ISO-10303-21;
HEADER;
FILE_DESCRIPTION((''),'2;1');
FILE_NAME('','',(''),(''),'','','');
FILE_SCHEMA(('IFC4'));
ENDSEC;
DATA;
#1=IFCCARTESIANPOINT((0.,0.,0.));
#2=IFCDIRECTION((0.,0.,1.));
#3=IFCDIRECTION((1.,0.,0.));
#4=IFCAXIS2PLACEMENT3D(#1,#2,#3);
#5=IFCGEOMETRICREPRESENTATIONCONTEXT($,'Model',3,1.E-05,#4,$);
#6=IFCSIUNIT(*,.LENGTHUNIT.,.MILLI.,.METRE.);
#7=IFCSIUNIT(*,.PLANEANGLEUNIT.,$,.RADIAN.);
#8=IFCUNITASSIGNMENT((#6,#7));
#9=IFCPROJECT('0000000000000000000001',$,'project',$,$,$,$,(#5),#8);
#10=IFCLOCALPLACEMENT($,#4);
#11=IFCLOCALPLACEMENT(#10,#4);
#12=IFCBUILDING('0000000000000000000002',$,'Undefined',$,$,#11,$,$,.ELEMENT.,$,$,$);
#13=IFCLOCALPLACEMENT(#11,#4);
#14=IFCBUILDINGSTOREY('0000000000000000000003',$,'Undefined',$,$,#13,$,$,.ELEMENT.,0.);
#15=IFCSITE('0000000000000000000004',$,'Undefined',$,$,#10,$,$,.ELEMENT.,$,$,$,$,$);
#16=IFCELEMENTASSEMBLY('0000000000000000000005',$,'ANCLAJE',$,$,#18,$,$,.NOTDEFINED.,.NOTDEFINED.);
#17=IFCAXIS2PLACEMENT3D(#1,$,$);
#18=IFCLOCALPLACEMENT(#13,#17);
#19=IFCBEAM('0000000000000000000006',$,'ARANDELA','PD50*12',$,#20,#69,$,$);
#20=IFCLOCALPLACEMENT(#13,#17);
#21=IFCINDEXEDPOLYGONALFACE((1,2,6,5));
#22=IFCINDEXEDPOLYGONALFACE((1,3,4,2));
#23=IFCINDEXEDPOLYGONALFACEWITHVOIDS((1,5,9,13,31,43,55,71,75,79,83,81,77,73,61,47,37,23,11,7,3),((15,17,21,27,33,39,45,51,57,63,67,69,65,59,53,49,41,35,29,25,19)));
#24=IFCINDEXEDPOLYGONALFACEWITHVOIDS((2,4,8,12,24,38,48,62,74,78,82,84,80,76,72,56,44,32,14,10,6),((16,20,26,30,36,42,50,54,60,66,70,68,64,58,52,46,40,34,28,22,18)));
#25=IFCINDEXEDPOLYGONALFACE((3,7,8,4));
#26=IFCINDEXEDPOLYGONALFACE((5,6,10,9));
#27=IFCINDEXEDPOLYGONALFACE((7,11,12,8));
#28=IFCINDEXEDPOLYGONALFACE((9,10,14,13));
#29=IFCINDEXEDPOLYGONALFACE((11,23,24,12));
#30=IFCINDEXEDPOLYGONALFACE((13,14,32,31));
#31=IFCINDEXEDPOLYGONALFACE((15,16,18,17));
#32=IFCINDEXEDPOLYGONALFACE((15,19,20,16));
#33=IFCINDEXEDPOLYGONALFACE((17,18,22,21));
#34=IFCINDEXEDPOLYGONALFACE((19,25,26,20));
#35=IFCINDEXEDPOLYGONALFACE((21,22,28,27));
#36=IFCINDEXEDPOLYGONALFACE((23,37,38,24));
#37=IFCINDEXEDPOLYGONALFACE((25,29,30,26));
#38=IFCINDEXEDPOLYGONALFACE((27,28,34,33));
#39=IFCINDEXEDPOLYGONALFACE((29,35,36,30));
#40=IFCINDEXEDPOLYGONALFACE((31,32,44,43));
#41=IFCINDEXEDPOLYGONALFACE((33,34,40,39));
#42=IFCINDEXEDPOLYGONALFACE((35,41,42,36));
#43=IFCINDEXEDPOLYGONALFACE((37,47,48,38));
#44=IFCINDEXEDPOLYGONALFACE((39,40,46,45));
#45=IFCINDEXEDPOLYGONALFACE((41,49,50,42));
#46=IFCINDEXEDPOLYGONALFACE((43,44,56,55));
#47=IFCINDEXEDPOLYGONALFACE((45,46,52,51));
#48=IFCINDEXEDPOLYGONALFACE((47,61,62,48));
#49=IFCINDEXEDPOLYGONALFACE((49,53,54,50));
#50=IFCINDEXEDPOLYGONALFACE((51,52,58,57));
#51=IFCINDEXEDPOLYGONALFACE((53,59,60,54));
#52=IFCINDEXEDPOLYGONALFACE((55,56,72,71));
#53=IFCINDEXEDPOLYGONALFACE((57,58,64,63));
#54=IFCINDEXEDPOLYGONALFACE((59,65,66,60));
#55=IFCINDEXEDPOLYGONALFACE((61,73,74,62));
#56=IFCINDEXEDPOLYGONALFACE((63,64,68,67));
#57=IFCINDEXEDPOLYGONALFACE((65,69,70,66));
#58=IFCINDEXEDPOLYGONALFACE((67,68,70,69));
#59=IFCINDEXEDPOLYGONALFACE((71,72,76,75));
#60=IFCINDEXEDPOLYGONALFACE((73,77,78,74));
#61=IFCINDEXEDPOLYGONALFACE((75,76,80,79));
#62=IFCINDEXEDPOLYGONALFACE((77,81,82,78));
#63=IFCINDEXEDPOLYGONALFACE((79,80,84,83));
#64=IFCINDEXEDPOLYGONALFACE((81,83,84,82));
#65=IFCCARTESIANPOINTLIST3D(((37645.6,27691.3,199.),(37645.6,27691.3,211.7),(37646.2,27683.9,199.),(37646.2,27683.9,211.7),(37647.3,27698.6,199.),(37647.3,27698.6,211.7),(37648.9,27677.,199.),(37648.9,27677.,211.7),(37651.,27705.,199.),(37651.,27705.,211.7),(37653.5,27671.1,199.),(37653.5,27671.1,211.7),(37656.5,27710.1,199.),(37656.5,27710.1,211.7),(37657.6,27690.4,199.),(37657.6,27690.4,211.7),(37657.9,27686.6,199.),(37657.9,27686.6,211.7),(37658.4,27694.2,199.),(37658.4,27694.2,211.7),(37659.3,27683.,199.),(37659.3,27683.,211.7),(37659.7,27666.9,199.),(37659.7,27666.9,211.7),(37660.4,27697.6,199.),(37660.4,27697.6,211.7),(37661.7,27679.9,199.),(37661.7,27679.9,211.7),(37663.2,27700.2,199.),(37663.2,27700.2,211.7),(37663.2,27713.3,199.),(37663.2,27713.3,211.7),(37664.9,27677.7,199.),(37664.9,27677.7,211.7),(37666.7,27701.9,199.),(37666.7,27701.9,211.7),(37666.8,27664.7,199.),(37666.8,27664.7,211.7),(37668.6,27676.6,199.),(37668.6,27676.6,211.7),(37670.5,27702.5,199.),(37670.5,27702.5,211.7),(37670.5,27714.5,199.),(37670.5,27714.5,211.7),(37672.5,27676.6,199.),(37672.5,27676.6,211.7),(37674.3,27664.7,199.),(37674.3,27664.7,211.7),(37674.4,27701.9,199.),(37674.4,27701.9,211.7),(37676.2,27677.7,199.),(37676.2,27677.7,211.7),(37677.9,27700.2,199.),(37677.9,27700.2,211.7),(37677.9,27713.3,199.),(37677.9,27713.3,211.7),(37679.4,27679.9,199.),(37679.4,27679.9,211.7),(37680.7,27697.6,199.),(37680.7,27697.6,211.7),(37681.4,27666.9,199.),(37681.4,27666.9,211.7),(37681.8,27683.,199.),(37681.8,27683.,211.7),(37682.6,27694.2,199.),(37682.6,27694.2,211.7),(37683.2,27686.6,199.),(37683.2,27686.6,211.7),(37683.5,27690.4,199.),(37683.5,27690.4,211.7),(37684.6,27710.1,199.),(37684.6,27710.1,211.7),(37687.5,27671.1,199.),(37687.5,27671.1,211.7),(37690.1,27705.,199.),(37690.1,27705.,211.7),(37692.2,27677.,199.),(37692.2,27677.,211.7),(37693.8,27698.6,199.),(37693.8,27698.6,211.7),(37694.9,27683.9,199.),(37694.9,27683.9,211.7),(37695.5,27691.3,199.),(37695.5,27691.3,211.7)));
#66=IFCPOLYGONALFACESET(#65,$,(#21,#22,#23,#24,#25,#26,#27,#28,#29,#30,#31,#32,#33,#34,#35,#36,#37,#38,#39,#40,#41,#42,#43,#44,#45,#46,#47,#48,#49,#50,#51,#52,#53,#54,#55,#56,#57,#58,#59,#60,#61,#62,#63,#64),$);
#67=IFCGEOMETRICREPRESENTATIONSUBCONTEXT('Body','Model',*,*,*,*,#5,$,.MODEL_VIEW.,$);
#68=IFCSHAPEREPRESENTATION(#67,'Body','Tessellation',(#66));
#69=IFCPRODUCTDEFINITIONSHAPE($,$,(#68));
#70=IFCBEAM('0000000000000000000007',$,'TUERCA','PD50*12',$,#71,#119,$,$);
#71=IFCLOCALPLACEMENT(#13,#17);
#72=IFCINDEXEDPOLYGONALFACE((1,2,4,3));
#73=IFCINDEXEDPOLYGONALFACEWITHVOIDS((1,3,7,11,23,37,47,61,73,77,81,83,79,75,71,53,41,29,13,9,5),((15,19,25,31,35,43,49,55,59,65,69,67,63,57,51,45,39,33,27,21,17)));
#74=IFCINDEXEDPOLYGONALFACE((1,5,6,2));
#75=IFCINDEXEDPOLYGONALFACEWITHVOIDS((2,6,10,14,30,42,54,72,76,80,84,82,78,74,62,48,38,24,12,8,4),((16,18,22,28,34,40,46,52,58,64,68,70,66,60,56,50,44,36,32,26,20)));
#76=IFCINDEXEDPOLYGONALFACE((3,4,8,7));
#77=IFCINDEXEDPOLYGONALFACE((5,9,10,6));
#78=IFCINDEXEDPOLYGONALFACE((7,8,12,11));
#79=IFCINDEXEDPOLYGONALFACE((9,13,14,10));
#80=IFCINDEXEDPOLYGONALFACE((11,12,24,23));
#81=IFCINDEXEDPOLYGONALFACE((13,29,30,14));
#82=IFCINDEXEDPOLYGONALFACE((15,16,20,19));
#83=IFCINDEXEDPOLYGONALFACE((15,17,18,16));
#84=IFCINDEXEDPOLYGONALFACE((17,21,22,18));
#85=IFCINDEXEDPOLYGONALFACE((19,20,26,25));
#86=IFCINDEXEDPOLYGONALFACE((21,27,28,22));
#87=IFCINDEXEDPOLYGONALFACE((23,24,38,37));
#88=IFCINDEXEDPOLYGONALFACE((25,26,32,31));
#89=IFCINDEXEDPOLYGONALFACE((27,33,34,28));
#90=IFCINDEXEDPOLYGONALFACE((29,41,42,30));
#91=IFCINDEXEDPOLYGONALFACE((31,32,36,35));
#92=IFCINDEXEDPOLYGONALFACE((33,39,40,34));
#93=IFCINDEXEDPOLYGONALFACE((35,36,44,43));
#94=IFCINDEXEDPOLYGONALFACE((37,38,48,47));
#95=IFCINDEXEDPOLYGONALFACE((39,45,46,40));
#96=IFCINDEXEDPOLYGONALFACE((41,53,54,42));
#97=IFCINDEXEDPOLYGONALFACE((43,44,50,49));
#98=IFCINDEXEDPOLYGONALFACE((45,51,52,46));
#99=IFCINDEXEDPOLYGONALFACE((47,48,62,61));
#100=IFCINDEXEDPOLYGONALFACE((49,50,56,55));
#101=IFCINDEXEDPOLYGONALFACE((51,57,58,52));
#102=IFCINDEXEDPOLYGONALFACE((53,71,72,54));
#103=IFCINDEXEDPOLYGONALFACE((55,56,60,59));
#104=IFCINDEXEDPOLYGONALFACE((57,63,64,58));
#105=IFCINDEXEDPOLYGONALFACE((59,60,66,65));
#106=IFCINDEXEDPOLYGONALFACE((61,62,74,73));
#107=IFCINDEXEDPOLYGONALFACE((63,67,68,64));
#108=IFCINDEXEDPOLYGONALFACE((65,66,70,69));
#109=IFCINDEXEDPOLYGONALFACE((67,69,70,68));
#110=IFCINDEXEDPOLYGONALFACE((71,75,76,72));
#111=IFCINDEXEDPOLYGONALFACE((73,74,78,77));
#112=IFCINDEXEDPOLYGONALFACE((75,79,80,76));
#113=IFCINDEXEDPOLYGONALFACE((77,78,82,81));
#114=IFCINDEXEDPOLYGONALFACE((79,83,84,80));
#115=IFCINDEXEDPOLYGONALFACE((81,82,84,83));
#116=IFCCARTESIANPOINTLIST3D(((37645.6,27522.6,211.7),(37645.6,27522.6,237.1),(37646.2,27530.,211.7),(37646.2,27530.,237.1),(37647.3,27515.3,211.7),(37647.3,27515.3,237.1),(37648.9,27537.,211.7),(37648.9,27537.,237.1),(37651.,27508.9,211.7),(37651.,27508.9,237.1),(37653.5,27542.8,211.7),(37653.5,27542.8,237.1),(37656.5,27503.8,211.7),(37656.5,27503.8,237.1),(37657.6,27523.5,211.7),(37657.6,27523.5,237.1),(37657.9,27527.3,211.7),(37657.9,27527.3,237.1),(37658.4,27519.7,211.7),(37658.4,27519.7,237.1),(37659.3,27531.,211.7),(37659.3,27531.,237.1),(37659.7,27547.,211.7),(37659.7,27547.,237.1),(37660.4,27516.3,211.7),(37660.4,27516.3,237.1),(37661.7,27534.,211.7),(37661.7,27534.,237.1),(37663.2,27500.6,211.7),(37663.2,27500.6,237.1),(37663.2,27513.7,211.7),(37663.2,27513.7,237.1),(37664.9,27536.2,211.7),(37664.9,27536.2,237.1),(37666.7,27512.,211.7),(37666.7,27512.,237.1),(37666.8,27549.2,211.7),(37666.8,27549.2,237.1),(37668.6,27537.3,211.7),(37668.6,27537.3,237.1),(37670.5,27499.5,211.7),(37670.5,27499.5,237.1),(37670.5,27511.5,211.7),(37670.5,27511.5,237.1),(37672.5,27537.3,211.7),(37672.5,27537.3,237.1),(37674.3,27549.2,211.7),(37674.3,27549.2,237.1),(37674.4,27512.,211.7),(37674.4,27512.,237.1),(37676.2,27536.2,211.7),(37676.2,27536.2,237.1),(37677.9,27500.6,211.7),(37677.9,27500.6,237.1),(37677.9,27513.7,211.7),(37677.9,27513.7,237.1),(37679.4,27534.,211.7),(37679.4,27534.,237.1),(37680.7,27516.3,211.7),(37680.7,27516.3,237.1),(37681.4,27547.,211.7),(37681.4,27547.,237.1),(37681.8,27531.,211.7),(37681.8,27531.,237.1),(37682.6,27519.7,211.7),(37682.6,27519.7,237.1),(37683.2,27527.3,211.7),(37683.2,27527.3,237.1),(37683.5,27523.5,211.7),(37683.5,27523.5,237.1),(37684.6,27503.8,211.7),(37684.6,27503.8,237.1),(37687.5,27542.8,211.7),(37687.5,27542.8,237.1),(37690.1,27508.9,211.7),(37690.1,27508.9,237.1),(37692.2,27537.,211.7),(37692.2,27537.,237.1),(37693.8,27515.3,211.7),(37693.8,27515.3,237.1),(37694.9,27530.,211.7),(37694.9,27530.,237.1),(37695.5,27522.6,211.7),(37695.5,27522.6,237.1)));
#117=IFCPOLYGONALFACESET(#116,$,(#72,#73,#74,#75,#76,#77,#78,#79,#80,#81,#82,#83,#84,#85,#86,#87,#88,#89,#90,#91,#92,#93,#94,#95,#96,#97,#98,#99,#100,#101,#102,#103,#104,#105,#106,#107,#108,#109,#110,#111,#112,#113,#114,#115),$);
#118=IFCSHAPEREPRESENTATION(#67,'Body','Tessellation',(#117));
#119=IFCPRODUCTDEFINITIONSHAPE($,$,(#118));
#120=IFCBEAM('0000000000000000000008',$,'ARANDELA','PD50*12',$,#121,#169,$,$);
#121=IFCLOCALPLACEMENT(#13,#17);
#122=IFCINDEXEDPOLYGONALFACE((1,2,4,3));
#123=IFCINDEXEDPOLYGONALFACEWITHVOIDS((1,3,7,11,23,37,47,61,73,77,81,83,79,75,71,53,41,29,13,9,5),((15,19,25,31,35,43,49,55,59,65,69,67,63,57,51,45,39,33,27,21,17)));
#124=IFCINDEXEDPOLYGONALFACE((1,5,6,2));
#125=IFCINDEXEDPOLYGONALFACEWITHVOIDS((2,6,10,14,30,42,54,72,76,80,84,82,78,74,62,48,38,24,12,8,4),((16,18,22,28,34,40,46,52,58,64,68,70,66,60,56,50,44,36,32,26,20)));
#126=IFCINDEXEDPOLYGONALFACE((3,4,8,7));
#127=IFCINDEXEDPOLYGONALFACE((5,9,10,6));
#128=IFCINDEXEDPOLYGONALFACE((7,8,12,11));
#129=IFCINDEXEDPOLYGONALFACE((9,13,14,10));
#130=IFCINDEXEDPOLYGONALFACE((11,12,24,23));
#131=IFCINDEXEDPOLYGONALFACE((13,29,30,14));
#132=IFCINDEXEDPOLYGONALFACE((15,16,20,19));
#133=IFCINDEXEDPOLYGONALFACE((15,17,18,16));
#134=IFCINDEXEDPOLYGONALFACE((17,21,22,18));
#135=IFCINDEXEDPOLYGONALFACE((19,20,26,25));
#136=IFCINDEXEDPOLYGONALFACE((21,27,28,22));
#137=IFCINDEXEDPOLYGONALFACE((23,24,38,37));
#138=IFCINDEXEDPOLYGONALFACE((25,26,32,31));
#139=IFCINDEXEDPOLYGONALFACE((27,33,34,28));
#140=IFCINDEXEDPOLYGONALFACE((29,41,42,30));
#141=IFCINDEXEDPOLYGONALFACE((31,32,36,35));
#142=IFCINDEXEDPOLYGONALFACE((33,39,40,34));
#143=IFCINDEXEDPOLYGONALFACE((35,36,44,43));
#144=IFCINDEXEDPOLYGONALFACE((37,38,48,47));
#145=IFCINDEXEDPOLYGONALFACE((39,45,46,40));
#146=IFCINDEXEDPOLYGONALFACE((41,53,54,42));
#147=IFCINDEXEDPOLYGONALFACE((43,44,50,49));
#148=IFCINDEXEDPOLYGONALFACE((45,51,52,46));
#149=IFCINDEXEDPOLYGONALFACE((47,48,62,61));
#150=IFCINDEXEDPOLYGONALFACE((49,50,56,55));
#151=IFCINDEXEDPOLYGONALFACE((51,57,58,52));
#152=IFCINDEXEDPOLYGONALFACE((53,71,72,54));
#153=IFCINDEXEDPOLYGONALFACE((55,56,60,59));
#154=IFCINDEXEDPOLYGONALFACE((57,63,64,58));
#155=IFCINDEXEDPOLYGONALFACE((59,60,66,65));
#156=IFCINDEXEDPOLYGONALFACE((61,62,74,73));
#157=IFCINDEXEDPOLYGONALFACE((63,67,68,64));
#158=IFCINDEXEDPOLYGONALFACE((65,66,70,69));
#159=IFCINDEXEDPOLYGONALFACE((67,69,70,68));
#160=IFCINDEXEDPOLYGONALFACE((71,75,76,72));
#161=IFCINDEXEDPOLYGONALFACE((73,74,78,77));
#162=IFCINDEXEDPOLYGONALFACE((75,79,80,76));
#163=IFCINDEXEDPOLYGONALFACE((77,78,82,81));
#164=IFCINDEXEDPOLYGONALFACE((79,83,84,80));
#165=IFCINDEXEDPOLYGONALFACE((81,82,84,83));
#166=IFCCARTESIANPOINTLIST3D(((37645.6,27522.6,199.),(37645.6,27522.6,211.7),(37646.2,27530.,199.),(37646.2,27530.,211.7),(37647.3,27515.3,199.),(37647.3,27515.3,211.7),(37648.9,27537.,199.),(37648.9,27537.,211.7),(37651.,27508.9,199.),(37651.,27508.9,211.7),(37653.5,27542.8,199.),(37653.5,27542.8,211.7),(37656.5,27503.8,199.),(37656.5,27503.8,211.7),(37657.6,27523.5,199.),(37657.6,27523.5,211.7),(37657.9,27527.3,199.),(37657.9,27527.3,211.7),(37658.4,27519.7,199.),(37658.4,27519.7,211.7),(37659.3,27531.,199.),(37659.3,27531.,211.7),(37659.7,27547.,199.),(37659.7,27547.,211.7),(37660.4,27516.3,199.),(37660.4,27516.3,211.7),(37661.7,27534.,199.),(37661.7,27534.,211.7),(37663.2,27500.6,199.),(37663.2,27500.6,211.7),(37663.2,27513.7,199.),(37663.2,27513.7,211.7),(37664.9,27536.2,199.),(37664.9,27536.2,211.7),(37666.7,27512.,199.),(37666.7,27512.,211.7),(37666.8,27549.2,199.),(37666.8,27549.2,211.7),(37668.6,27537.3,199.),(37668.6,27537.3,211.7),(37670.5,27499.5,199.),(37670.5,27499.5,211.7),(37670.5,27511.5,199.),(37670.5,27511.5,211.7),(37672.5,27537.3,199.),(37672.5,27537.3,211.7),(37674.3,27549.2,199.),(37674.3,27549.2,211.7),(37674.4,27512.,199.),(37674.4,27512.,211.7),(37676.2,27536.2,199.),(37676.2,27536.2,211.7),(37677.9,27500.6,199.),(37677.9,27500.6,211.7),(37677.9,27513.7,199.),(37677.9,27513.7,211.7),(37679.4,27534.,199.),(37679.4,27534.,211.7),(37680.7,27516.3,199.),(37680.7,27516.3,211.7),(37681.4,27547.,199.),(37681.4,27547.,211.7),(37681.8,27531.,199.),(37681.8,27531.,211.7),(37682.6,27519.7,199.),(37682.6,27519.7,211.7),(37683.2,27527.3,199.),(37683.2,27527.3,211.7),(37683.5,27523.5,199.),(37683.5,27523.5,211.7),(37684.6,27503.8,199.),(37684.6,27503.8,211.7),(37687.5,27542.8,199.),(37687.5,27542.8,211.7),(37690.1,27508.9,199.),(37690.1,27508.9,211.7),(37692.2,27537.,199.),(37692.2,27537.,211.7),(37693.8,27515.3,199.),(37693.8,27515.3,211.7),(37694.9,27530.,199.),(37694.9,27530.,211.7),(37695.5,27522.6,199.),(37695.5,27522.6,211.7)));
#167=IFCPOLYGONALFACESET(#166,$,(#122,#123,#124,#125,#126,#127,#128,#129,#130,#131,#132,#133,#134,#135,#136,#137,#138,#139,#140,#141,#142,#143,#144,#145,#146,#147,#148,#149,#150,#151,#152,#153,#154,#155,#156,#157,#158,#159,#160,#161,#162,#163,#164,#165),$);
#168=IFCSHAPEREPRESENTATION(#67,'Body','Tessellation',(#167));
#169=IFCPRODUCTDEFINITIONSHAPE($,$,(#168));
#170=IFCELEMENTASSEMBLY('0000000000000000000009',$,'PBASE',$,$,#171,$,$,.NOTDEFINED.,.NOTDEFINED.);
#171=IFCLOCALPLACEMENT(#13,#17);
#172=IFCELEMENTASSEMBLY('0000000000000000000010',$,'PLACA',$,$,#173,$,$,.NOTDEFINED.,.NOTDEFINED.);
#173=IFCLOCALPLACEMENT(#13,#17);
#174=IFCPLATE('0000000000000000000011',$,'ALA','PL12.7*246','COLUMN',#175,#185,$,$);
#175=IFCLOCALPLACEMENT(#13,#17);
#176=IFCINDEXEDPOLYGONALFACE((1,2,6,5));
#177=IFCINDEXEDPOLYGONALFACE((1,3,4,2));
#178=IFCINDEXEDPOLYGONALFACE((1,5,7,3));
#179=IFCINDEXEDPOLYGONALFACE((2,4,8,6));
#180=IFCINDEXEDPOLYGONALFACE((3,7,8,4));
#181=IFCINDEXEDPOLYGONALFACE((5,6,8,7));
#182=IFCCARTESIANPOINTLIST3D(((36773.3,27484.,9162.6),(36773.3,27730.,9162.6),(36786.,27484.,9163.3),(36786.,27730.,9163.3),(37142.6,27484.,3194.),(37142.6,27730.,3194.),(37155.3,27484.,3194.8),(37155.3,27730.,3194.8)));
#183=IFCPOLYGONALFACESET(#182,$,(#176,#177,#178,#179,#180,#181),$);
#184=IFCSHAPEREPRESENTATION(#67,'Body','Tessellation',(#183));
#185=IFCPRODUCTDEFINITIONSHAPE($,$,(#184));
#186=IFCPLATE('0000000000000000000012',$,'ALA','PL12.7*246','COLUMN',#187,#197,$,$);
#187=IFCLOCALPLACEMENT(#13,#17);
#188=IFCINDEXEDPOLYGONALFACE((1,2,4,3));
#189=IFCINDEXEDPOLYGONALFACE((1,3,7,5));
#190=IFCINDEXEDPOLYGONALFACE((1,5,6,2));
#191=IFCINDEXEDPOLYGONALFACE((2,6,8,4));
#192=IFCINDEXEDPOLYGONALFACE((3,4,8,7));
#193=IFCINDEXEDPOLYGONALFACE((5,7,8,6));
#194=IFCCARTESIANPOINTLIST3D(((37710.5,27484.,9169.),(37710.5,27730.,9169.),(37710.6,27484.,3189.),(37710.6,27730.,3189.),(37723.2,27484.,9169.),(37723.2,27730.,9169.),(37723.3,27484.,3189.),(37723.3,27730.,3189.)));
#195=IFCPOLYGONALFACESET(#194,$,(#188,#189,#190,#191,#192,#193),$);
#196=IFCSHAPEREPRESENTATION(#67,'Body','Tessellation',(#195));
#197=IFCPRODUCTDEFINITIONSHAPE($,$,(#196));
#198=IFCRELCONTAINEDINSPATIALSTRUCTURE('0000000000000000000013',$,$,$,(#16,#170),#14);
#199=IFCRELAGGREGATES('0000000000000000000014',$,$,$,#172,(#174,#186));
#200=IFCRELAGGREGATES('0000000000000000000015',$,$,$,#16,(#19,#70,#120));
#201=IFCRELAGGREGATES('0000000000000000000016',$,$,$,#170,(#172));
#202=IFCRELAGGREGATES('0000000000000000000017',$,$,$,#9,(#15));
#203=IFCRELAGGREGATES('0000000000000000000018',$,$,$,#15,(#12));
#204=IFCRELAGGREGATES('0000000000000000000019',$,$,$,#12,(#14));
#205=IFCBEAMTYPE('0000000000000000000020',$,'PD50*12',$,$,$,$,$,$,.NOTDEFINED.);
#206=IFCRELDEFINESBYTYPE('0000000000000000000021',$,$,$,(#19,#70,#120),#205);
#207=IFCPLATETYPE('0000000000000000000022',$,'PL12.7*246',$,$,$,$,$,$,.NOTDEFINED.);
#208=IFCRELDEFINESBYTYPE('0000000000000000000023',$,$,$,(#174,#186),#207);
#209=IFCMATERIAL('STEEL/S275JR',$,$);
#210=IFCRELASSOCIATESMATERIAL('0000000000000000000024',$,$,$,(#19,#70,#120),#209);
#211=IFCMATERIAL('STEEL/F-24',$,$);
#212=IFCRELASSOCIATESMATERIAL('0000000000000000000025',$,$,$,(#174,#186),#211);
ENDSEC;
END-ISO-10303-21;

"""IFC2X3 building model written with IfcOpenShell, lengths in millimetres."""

from ifc_helpers import new_model, si_unit, frame, origin_with_axes, origin_2d_with_axis, place, context, subcontext, project, spatial, polyline, hollow_circle, outline, extrude, material, type_object, element, aggregate, save


model = new_model("IFC2X3")

# Units and contexts
model_context = context("Model", 3, precision=1e-05, world=origin_with_axes())
body_context = subcontext(model_context, "Body", "Model", "MODEL_VIEW")
ifc_project = project(units=[si_unit("LENGTHUNIT", "METRE", prefix="MILLI"), si_unit("PLANEANGLEUNIT", "RADIAN")], contexts=[model_context])

# Site, building, storey
site_placement = place(None, origin_with_axes())
site = spatial("IfcSite", under=ifc_project, at=site_placement, Name="Undefined", CompositionType="ELEMENT")
building_placement = place(site_placement, origin_with_axes())
building = spatial("IfcBuilding", under=site, at=building_placement, Name="Undefined", CompositionType="ELEMENT")
storey_placement = place(building_placement, origin_with_axes())
storey = spatial("IfcBuildingStorey", under=building, at=storey_placement, Name="Undefined", CompositionType="ELEMENT", Elevation=0.0)

# Shared definitions
ifc_material_1 = material(Name="STEEL/F-24")

# Element assembly, beams
assembly_1_placement = place(storey_placement, origin_with_axes())
assembly_1 = element("IfcElementAssembly", 1, at=assembly_1_placement, inside=storey, Name="ANCLAJE", AssemblyPlace="NOTDEFINED", PredefinedType="NOTDEFINED")
ifc_material_2 = material(Name="STEEL/S275JR")
beam_type_1 = type_object("IfcBeamType", Name="PD50*12", PredefinedType="NOTDEFINED")
beam_1_placement = place(assembly_1_placement, frame((37670.5, 27689.5, 211.7), z_axis=(-1.0, 0.0, 0.0), x_axis=(0.0, 0.0, -1.0)))
beam_1 = element("IfcBeam", 2, at=beam_1_placement, type_object=beam_type_1, material=ifc_material_2, Name="ARANDELA", Description="PD50*12", context=body_context, shape_type="SweptSolid", body=[
    extrude(hollow_circle(Radius=25.0, WallThickness=12.0, at=origin_2d_with_axis()), frame((12.7, 0.0, 0.0), z_axis=(-1.0, 0.0, 0.0), x_axis=(0.0, -1.0, 0.0)), (0.0, 0.0, 1.0), 12.7),
])
beam_2_placement = place(assembly_1_placement, frame((37670.5, 27524.5, 237.1), z_axis=(1.0, 0.0, 0.0), x_axis=(0.0, 0.0, -1.0)))
beam_2 = element("IfcBeam", 3, at=beam_2_placement, type_object=beam_type_1, material=ifc_material_2, Name="TUERCA", Description="PD50*12", context=body_context, shape_type="SweptSolid", body=[
    extrude(hollow_circle(Radius=25.0, WallThickness=12.0, at=origin_2d_with_axis()), frame((25.4, 0.0, 0.0), z_axis=(-1.0, 0.0, 0.0), x_axis=(0.0, -1.0, 0.0)), (0.0, 0.0, 1.0), 25.4),
])
beam_3_placement = place(assembly_1_placement, frame((37670.5, 27524.5, 211.7), z_axis=(1.0, 0.0, 0.0), x_axis=(0.0, 0.0, -1.0)))
beam_3 = element("IfcBeam", 4, at=beam_3_placement, type_object=beam_type_1, material=ifc_material_2, Name="ARANDELA", Description="PD50*12", context=body_context, shape_type="SweptSolid", body=[
    extrude(hollow_circle(Radius=25.0, WallThickness=12.0, at=origin_2d_with_axis()), frame((12.7, 0.0, 0.0), z_axis=(-1.0, 0.0, 0.0), x_axis=(0.0, -1.0, 0.0)), (0.0, 0.0, 1.0), 12.7),
])

# Element assemblies, plates
assembly_2_placement = place(storey_placement, origin_with_axes())
assembly_2 = element("IfcElementAssembly", 5, at=assembly_2_placement, inside=storey, Name="PBASE", AssemblyPlace="NOTDEFINED", PredefinedType="NOTDEFINED")
assembly_3_placement = place(assembly_2_placement, origin_with_axes())
assembly_3 = element("IfcElementAssembly", 6, at=assembly_3_placement, Name="PLACA", AssemblyPlace="NOTDEFINED", PredefinedType="NOTDEFINED")
plate_type_1 = type_object("IfcPlateType", Name="PL12.7*246", PredefinedType="NOTDEFINED")
plate_1_placement = place(assembly_3_placement, frame((37148.9, 27607.0, 3194.4), z_axis=(-0.998091, 0.0, -0.061754), x_axis=(-0.061754, 0.0, 0.998091)))
plate_1 = element("IfcPlate", 7, at=plate_1_placement, type_object=plate_type_1, material=ifc_material_1, Name="ALA", Description="PL12.7*246", ObjectType="COLUMN", context=body_context, shape_type="SweptSolid", body=[
    extrude(outline(polyline([(0.0, -123.0), (0.0, 123.0), (5980.0, 123.0), (5980.0, -123.0), (0.0, -123.0)])), frame((0.0, 0.0, -6.3), z_axis=(0.0, 0.0, 1.0), x_axis=(1.0, 0.0, 0.0)), (0.0, 0.0, 1.0), 12.7),
])
plate_2_placement = place(assembly_3_placement, frame((37716.9, 27607.0, 3189.0), z_axis=(-1.0, 0.0, -0.000009), x_axis=(-0.000009, 0.0, 1.0)))
plate_2 = element("IfcPlate", 8, at=plate_2_placement, type_object=plate_type_1, material=ifc_material_1, Name="ALA", Description="PL12.7*246", ObjectType="COLUMN", context=body_context, shape_type="SweptSolid", body=[
    extrude(outline(polyline([(0.0, -123.0), (0.0, 123.0), (5980.0, 123.0), (5980.0, -123.0), (0.0, -123.0)])), frame((0.0, 0.0, -6.3), z_axis=(0.0, 0.0, 1.0), x_axis=(1.0, 0.0, 0.0)), (0.0, 0.0, 1.0), 12.7),
])
aggregate(assembly_3, [plate_1, plate_2])

aggregate(assembly_1, [beam_1, beam_2, beam_3])
aggregate(assembly_2, [assembly_3])

save(model, "model.ifc")
